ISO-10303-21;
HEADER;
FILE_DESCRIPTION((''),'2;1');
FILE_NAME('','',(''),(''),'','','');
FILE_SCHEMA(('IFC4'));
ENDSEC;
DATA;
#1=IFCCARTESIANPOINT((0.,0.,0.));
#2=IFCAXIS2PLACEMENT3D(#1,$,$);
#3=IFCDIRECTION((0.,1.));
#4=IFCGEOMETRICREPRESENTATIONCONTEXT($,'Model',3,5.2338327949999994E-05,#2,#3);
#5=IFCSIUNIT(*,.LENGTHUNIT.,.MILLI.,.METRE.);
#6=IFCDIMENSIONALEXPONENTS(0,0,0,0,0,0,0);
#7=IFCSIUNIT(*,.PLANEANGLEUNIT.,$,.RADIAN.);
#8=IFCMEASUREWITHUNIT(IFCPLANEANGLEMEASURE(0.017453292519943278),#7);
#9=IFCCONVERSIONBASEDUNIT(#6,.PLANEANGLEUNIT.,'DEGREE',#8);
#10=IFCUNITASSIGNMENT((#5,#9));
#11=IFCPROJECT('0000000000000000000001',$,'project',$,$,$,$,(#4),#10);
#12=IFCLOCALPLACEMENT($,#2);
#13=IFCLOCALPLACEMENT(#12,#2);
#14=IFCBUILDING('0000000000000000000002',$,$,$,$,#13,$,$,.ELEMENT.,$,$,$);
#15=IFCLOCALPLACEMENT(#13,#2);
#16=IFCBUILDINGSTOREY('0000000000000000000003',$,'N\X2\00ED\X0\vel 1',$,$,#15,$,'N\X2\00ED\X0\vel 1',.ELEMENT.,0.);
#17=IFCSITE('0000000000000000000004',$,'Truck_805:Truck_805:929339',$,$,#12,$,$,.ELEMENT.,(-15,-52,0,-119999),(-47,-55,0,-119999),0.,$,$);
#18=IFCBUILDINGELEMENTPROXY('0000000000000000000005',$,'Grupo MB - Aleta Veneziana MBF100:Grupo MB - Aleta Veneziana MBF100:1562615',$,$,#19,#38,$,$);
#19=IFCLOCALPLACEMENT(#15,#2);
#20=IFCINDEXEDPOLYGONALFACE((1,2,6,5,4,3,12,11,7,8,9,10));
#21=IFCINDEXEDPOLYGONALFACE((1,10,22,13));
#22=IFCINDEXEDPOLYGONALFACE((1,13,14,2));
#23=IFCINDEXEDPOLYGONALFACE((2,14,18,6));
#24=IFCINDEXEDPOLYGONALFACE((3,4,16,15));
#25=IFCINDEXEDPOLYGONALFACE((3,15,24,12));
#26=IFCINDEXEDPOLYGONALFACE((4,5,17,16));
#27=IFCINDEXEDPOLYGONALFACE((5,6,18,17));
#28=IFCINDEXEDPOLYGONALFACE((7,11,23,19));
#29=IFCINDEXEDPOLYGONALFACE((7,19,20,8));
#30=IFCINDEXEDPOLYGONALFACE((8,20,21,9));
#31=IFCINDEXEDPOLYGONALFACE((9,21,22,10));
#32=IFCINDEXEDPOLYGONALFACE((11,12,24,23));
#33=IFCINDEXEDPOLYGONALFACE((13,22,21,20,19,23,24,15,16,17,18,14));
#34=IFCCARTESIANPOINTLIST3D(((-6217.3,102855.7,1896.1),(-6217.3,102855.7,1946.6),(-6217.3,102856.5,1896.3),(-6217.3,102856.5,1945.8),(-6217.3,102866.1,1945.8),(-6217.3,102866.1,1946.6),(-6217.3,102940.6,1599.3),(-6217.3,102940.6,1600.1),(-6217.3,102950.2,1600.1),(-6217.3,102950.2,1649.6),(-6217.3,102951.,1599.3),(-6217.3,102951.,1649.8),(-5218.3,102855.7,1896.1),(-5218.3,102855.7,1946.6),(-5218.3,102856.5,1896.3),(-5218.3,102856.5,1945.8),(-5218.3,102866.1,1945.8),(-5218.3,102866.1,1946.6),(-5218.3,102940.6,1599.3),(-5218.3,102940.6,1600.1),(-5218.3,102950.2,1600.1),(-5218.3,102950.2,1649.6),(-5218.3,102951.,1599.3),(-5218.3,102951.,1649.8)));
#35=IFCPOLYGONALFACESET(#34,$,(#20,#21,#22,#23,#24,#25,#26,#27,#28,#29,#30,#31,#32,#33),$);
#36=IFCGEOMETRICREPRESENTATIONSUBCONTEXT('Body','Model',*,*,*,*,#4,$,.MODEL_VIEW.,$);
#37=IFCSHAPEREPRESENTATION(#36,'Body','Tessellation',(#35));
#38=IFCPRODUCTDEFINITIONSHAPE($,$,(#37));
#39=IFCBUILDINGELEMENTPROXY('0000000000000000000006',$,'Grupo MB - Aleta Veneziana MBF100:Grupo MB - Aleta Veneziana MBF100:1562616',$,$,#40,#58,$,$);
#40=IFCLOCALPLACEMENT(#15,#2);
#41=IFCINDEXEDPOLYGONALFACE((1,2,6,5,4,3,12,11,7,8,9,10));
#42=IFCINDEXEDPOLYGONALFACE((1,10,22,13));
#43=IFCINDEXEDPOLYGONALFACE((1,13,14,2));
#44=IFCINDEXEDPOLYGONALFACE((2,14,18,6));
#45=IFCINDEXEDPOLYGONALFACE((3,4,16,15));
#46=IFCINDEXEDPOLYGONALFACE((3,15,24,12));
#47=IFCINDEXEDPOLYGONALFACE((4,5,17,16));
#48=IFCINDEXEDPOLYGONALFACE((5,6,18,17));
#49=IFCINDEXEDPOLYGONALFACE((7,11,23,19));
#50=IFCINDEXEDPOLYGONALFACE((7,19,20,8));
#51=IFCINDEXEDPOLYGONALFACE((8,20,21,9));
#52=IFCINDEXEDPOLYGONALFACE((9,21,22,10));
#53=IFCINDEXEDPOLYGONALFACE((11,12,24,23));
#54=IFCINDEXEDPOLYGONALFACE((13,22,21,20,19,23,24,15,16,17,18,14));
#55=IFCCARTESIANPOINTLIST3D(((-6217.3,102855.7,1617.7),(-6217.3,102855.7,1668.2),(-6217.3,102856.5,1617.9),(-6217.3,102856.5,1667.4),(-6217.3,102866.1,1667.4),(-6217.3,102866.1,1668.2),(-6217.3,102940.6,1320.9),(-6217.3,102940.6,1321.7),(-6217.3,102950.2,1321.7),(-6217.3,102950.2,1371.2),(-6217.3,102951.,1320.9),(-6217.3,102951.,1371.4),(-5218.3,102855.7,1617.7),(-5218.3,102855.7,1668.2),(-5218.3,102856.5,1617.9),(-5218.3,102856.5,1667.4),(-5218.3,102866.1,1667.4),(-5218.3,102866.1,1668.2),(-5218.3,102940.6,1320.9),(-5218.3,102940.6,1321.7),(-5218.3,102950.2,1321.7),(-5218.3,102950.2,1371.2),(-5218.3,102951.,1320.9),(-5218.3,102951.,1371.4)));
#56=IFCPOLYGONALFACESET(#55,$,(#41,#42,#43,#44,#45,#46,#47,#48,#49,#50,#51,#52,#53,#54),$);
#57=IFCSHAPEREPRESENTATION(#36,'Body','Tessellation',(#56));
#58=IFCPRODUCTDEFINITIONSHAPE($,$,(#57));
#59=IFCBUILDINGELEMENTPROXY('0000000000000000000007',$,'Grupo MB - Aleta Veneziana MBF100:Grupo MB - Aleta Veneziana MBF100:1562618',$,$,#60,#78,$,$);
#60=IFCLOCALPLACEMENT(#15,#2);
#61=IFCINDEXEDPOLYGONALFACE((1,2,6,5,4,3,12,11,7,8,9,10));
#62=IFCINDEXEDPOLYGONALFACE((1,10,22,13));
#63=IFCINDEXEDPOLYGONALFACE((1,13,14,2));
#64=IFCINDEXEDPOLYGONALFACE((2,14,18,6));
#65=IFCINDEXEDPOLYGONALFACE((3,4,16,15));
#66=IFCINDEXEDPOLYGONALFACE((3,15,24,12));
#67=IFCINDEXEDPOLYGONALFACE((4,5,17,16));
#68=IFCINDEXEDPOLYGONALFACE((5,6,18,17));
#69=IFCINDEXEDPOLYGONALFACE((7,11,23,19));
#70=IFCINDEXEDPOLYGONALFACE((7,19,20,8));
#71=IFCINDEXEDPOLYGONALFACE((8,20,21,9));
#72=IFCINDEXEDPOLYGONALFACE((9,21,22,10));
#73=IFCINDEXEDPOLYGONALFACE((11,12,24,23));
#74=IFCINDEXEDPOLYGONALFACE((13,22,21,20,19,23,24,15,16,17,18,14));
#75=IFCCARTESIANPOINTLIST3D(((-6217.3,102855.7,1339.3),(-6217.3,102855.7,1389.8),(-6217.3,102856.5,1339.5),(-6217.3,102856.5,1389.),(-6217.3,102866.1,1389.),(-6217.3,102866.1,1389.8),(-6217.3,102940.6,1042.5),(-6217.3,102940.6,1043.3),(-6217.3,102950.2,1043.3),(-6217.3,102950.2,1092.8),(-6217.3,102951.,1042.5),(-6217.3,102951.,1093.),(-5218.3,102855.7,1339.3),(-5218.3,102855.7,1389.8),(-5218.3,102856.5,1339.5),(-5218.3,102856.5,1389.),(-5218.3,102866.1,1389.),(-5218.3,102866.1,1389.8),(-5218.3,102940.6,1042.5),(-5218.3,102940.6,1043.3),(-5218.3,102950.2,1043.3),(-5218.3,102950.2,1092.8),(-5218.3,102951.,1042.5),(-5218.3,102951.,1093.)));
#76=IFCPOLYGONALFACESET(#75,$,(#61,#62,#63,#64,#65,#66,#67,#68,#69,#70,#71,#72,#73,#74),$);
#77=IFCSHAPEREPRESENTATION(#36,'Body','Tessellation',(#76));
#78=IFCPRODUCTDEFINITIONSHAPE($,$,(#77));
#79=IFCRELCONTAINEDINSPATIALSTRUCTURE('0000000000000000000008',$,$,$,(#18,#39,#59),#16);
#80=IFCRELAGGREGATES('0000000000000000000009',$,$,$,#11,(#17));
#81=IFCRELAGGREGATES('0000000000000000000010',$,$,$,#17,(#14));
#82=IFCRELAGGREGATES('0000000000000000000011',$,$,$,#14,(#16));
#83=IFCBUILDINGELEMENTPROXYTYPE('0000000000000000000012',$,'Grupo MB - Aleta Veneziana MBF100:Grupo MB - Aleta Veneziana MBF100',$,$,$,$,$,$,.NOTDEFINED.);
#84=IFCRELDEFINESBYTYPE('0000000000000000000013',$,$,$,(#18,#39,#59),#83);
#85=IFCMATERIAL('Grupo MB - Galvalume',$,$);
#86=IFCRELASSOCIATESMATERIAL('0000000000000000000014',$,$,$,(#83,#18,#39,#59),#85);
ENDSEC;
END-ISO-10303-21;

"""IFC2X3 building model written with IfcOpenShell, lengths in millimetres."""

from ifc_helpers import new_model, entity, si_unit, converted_unit, direction, frame, origin, place, context, subcontext, project, spatial, polyline, outline, extrude, source, transform, mapped, material, type_object, type_shapes, element, save


model = new_model("IFC2X3")

# Units and contexts
model_context = context("Model", 3, precision=5.2338327949999994e-05, world=origin(), true_north=direction((0.0, 1.0)))
body_context = subcontext(model_context, "Body", "Model", "MODEL_VIEW")
ifc_project = project(units=[si_unit("LENGTHUNIT", "METRE", prefix="MILLI"), converted_unit("PLANEANGLEUNIT", "DEGREE", entity("IfcPlaneAngleMeasure", 0.017453292519943278), si_unit("PLANEANGLEUNIT", "RADIAN"), dimensions=[0, 0, 0, 0, 0, 0, 0])], contexts=[model_context])

# Site, building, storey
site_placement = place(None, origin())
site = spatial("IfcSite", under=ifc_project, at=site_placement, Name="Truck_805:Truck_805:929339", CompositionType="ELEMENT", RefLatitude=(-15, -52, 0, -119999), RefLongitude=(-47, -55, 0, -119999), RefElevation=0.0)
building_placement = place(site_placement, origin())
building = spatial("IfcBuilding", under=site, at=building_placement, CompositionType="ELEMENT")
storey_placement = place(building_placement, origin())
storey = spatial("IfcBuildingStorey", under=building, at=storey_placement, Name="Nível 1", LongName="Nível 1", CompositionType="ELEMENT", Elevation=0.0)

# Building element proxies
ifc_material_1 = material(Name="Grupo MB - Galvalume")
building_element_proxy_type_1 = type_object("IfcBuildingElementProxyType", Name="Grupo MB - Aleta Veneziana MBF100:Grupo MB - Aleta Veneziana MBF100", PredefinedType="NOTDEFINED", material=ifc_material_1)
shared_shape_1 = source(origin(), body_context, "Body", "SweptSolid", [
    extrude(outline(polyline([(123.3, -46.8), (-123.2, 47.6), (-173.7, 47.6), (-173.7, 37.2), (-172.9, 37.2), (-172.9, 46.8), (-123.3, 46.8), (123.2, -47.6), (173.7, -47.6), (173.7, -37.2), (172.9, -37.2), (172.9, -46.8), (123.3, -46.8)])), frame((0.0, 47.6, 173.7), z_axis=(-1.0, 0.0, 0.0), x_axis=(0.0, 0.0, -1.0)), (0.0, 0.0, -1.0), 999.0),
])
type_shapes(building_element_proxy_type_1, [shared_shape_1])
for number, where, name in (
    (1, (-6217.3, 102855.7, 1599.3), "Grupo MB - Aleta Veneziana MBF100:Grupo MB - Aleta Veneziana MBF100:1562615"),
    (2, (-6217.3, 102855.7, 1320.9), "Grupo MB - Aleta Veneziana MBF100:Grupo MB - Aleta Veneziana MBF100:1562616"),
    (3, (-6217.3, 102855.7, 1042.5), "Grupo MB - Aleta Veneziana MBF100:Grupo MB - Aleta Veneziana MBF100:1562618"),
):
    element("IfcBuildingElementProxy", number, at=place(storey_placement, frame(where)), inside=storey, type_object=building_element_proxy_type_1, material=ifc_material_1, Name=name, context=body_context, shape_type="MappedRepresentation", body=[
        mapped(shared_shape_1, transform((0.0, 0.0, 0.0), scale=1.0)),
    ])

save(model, "model.ifc")
